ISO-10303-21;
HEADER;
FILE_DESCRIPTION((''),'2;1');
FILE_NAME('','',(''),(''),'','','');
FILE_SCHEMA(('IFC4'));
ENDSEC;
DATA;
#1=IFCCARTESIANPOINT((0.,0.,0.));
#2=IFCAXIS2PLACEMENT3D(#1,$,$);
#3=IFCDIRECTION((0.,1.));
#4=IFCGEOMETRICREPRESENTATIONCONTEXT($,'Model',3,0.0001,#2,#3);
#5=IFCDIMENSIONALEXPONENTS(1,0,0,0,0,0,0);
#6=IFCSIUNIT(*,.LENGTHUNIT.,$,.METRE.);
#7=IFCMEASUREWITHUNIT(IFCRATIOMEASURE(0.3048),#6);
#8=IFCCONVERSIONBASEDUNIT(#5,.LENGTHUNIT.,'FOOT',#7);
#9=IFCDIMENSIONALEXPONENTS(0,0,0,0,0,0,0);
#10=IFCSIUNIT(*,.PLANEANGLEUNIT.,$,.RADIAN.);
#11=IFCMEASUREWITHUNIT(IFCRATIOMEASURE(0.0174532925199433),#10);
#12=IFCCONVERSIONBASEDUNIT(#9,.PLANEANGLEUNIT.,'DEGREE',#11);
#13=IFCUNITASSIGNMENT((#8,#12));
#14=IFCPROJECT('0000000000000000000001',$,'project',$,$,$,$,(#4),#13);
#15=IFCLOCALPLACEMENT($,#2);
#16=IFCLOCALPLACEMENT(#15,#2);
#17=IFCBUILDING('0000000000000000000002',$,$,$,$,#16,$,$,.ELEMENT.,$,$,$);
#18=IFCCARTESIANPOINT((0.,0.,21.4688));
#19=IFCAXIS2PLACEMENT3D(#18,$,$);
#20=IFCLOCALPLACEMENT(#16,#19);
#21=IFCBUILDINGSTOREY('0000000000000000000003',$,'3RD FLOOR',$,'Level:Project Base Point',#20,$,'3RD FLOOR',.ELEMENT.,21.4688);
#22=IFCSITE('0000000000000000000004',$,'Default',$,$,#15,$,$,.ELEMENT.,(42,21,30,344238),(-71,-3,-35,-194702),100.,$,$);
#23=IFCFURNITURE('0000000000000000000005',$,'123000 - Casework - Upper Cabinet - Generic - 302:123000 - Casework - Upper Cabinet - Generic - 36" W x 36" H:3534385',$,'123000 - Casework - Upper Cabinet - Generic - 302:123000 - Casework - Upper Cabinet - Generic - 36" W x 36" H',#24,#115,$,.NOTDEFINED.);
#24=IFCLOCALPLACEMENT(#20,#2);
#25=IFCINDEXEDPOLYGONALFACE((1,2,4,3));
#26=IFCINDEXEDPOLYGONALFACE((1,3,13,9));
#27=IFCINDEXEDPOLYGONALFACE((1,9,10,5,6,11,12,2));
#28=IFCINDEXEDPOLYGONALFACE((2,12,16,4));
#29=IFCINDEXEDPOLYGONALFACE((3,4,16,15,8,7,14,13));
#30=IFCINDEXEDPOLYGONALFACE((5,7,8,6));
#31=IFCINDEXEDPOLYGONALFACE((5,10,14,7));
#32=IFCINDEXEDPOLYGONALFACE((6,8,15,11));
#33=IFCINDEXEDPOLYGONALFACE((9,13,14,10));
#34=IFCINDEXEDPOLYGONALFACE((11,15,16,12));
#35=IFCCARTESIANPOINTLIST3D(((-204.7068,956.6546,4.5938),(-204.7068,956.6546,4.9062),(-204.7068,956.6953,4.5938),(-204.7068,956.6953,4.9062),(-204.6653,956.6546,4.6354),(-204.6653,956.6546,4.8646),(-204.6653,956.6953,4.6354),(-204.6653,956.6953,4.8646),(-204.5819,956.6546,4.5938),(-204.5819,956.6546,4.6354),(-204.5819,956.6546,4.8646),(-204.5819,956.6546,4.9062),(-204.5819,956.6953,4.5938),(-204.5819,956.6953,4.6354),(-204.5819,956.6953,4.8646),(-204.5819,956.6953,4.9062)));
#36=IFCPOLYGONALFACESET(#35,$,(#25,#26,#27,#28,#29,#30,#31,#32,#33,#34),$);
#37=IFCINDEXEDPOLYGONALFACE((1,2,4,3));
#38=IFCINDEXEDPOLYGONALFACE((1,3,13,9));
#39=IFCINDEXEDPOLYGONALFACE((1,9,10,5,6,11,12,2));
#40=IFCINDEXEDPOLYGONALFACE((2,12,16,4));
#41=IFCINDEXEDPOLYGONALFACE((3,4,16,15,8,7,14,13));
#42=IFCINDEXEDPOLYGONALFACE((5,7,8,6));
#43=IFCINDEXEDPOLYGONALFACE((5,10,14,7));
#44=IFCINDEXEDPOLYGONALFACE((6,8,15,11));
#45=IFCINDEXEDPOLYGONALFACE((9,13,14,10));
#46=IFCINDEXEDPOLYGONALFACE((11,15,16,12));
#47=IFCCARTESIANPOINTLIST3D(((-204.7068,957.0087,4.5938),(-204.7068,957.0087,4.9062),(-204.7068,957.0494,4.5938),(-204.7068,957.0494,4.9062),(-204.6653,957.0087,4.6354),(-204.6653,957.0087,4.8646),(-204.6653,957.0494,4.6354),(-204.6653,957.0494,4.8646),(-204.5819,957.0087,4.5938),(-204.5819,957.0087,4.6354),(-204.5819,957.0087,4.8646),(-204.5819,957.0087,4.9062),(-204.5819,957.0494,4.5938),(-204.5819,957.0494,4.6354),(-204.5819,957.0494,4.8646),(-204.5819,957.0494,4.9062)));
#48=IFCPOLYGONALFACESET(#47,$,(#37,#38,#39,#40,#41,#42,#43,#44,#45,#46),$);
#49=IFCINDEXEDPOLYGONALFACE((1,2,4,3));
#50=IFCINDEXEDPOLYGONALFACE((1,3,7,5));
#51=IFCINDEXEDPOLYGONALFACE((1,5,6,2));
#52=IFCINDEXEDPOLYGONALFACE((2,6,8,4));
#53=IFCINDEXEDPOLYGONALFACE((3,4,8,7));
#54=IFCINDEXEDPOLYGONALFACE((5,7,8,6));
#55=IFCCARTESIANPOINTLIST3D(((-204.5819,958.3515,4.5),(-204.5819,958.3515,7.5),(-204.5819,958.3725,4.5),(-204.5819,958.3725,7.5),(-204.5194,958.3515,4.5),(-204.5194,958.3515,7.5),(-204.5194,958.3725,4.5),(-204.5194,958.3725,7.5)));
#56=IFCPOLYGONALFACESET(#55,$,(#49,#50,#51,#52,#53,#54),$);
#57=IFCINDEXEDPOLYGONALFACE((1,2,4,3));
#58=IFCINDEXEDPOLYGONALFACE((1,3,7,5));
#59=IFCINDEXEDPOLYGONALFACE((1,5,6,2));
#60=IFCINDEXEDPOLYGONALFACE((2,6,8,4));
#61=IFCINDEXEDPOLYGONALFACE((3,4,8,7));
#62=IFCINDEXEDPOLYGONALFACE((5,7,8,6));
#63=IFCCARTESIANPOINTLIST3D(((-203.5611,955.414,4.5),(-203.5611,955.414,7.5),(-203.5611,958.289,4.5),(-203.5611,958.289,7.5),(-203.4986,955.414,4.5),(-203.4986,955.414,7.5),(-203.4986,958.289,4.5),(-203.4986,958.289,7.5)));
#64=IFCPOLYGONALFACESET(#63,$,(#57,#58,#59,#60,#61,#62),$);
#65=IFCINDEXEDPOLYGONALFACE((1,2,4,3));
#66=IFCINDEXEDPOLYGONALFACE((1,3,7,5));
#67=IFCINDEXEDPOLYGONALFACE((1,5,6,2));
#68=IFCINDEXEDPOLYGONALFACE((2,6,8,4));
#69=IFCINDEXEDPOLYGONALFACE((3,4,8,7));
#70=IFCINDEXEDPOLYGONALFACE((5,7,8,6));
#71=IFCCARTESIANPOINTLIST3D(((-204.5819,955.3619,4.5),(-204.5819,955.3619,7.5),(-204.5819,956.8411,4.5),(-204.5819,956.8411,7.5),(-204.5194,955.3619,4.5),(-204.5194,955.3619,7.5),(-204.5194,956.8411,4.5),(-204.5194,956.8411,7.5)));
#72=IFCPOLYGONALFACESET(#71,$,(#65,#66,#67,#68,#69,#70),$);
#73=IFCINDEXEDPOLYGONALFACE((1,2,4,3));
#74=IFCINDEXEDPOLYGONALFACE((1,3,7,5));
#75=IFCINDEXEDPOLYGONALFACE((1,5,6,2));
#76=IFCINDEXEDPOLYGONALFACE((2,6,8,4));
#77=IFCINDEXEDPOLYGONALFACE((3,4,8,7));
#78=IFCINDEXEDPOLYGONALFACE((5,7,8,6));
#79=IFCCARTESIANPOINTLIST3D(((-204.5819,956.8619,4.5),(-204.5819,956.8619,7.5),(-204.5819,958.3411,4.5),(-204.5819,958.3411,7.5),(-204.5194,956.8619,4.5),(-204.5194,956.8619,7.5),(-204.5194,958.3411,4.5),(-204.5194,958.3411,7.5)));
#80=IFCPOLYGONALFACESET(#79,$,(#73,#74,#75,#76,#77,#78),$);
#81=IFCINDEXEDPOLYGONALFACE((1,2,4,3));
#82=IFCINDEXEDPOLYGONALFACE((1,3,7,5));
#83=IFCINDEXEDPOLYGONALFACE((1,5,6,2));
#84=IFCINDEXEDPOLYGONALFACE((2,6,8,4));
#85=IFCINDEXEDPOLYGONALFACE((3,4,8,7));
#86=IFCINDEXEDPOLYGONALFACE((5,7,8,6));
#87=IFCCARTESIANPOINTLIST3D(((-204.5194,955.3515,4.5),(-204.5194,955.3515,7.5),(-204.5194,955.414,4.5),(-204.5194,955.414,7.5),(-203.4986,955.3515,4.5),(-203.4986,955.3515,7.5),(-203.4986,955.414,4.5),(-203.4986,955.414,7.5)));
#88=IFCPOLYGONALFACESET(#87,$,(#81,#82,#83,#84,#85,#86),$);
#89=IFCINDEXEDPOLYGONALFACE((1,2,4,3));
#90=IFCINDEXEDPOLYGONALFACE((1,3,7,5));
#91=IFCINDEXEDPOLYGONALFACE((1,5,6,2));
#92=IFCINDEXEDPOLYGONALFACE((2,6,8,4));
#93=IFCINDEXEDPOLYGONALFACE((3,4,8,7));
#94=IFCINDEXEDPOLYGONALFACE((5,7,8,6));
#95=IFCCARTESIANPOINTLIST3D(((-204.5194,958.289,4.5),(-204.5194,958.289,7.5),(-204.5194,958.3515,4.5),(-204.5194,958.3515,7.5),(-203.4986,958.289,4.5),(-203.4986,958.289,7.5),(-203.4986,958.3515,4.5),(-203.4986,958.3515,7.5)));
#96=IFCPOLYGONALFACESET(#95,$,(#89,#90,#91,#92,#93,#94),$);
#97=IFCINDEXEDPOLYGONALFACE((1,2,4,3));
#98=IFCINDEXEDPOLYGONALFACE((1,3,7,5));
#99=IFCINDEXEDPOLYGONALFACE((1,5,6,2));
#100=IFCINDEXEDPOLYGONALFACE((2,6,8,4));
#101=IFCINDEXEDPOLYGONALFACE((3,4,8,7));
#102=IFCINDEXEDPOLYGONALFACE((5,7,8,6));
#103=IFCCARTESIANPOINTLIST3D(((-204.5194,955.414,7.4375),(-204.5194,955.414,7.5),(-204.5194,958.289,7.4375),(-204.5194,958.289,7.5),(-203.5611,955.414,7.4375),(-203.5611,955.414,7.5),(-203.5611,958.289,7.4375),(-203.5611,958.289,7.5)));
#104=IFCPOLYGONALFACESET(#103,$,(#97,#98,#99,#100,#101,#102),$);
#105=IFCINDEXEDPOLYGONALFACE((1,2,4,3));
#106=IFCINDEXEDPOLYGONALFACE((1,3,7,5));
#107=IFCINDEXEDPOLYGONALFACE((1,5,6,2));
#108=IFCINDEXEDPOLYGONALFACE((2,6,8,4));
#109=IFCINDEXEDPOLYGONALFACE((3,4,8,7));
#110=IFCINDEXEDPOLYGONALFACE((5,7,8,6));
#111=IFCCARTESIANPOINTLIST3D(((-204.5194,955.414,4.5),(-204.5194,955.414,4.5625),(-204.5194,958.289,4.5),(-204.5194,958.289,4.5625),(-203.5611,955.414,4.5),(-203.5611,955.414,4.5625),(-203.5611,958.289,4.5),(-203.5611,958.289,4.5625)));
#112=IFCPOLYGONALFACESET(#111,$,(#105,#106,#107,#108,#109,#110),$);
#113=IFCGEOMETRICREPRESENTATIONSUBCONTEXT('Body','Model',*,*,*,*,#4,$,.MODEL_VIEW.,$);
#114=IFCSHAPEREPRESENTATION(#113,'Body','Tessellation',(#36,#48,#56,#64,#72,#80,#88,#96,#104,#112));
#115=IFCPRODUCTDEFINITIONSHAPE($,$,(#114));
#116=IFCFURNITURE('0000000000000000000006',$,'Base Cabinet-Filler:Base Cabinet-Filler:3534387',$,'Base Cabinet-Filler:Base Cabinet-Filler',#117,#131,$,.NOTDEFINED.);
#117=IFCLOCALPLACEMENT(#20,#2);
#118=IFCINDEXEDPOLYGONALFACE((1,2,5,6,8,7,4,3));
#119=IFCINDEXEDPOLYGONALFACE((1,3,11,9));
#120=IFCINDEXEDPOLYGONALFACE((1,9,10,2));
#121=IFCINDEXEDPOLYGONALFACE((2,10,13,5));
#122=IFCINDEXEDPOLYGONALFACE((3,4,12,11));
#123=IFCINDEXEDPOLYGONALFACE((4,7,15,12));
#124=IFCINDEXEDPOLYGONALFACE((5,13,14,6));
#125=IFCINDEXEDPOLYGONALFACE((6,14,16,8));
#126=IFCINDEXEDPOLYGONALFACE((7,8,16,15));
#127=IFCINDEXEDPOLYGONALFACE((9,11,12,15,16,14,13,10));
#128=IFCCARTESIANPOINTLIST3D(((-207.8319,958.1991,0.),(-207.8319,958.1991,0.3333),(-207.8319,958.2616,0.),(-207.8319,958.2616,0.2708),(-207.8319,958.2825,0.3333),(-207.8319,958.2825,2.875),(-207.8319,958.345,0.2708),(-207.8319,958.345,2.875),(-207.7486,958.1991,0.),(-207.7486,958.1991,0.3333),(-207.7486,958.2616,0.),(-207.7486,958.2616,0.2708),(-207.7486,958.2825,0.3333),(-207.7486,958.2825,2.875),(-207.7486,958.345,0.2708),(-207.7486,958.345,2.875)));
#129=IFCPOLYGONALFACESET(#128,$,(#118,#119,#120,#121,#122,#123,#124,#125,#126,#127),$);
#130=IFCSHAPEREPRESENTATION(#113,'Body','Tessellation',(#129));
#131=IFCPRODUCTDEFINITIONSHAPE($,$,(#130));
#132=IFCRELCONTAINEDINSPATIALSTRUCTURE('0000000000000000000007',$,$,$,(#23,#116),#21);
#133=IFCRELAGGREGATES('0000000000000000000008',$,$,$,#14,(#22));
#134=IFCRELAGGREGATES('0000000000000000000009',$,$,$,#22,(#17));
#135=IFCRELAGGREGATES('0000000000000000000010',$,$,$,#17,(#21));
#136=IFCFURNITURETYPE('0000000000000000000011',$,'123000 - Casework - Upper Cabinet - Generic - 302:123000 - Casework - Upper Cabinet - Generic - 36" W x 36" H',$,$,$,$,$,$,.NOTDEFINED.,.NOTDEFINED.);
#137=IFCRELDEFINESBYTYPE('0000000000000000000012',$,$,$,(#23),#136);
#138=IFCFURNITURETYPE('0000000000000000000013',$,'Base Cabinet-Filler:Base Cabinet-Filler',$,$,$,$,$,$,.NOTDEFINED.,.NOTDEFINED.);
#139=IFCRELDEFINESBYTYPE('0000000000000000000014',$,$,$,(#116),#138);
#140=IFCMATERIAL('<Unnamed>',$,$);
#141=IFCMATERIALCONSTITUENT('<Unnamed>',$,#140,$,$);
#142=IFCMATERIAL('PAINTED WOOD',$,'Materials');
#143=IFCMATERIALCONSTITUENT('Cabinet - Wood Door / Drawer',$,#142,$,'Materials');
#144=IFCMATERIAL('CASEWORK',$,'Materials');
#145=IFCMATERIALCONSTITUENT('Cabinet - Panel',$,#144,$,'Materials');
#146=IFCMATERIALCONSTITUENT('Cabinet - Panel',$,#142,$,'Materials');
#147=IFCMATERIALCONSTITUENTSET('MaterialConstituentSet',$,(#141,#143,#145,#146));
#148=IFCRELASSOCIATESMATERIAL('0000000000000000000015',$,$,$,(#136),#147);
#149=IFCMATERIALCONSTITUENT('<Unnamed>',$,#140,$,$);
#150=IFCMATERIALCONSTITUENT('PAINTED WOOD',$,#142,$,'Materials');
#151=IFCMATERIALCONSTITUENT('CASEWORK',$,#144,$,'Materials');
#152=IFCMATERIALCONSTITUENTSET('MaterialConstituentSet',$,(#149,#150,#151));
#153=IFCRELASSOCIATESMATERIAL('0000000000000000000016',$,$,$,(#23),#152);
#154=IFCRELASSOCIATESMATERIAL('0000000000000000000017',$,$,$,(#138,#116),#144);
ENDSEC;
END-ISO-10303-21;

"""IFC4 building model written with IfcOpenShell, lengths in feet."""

from ifc_helpers import new_model, entity, si_unit, converted_unit, direction, frame, frame_2d, origin, origin_2d_with_axis, place, context, subcontext, project, spatial, polyline, rectangle, outline, extrude, source, transform, mapped, material, constituent, constituent_set, type_object, type_shapes, element, save


model = new_model("IFC4")

# Units and contexts
model_context = context("Model", 3, precision=0.0001, world=origin(), true_north=direction((0.0, 1.0)))
body_context = subcontext(model_context, "Body", "Model", "MODEL_VIEW")
ifc_project = project(units=[converted_unit("LENGTHUNIT", "FOOT", entity("IfcRatioMeasure", 0.3048), si_unit("LENGTHUNIT", "METRE"), dimensions=[1, 0, 0, 0, 0, 0, 0]), converted_unit("PLANEANGLEUNIT", "DEGREE", entity("IfcRatioMeasure", 0.0174532925199433), si_unit("PLANEANGLEUNIT", "RADIAN"), dimensions=[0, 0, 0, 0, 0, 0, 0])], contexts=[model_context])

# Site, building, storey
site_placement = place(None, origin())
site = spatial("IfcSite", under=ifc_project, at=site_placement, Name="Default", CompositionType="ELEMENT", RefLatitude=(42, 21, 30, 344238), RefLongitude=(-71, -3, -35, -194702), RefElevation=100.0)
building_placement = place(site_placement, origin())
building = spatial("IfcBuilding", under=site, at=building_placement, CompositionType="ELEMENT")
storey_placement = place(building_placement, frame((0.0, 0.0, 21.4688)))
storey = spatial("IfcBuildingStorey", under=building, at=storey_placement, Name="3RD FLOOR", ObjectType="Level:Project Base Point", LongName="3RD FLOOR", CompositionType="ELEMENT", Elevation=21.4688)

# Furniture
ifc_material_1 = material(Name="CASEWORK", Category="Materials")
ifc_material_2 = material(Name="<Unnamed>")
ifc_material_3 = material(Name="PAINTED WOOD", Category="Materials")
ifc_constituent_1 = constituent(ifc_material_2, Name="<Unnamed>")
ifc_constituent_2 = constituent(ifc_material_3, Name="PAINTED WOOD", Category="Materials")
ifc_constituent_3 = constituent(ifc_material_1, Name="CASEWORK", Category="Materials")
ifc_constituent_set_1 = constituent_set(constituents=[ifc_constituent_1, ifc_constituent_2, ifc_constituent_3], Name="MaterialConstituentSet")
ifc_constituent_4 = constituent(ifc_material_2, Name="<Unnamed>")
ifc_constituent_5 = constituent(ifc_material_3, Name="Cabinet - Wood Door / Drawer", Category="Materials")
ifc_constituent_6 = constituent(ifc_material_1, Name="Cabinet - Panel", Category="Materials")
ifc_constituent_7 = constituent(ifc_material_3, Name="Cabinet - Panel", Category="Materials")
ifc_constituent_set_2 = constituent_set(constituents=[ifc_constituent_4, ifc_constituent_5, ifc_constituent_6, ifc_constituent_7], Name="MaterialConstituentSet")
furniture_type_1 = type_object("IfcFurnitureType", Name="123000 - Casework - Upper Cabinet - Generic - 302:123000 - Casework - Upper Cabinet - Generic - 36\" W x 36\" H", AssemblyPlace="NOTDEFINED", PredefinedType="NOTDEFINED", material=ifc_constituent_set_2)
shared_shape_1 = source(origin(), body_context, "Body", "SweptSolid", [
    extrude(outline(polyline([(-0.0521, -0.1146), (-0.0521, -0.1562), (0.0729, -0.1562), (0.0729, 0.1562), (-0.0521, 0.1562), (-0.0521, 0.1146), (0.0313, 0.1146), (0.0313, -0.1146), (-0.0521, -0.1146)])), frame((1.303, 1.1354, 0.25), z_axis=(-1.0, 0.0, 0.0), x_axis=(0.0, 1.0, 0.0)), (0.0, 0.0, -1.0), 0.0407),
    extrude(outline(polyline([(-0.0521, -0.1146), (-0.0521, -0.1562), (0.0729, -0.1562), (0.0729, 0.1562), (-0.0521, 0.1562), (-0.0521, 0.1146), (0.0313, 0.1146), (0.0313, -0.1146), (-0.0521, -0.1146)])), frame((1.6572, 1.1354, 0.25), z_axis=(-1.0, 0.0, 0.0), x_axis=(0.0, 1.0, 0.0)), (0.0, 0.0, -1.0), 0.0407),
    extrude(rectangle(XDim=0.021, YDim=0.0625, at=frame_2d((0.0, 0.0), x_axis=(1.0, 0.0))), frame((3.0105, 1.0521, 0.0)), (0.0, 0.0, 1.0), 3.0),
    extrude(rectangle(XDim=2.875, YDim=0.0625, at=frame_2d((0.0, 0.0), x_axis=(1.0, 0.0))), frame((1.5, 0.0313, 0.0), z_axis=(0.0, 0.0, 1.0), x_axis=(-1.0, 0.0, 0.0)), (0.0, 0.0, 1.0), 3.0),
    extrude(rectangle(XDim=1.4792, YDim=0.0625, at=origin_2d_with_axis()), frame((0.75, 1.0521, 0.0)), (0.0, 0.0, 1.0), 3.0),
    extrude(rectangle(XDim=1.4792, YDim=0.0625, at=origin_2d_with_axis()), frame((2.25, 1.0521, 0.0)), (0.0, 0.0, 1.0), 3.0),
    extrude(rectangle(XDim=1.0208, YDim=0.0625, at=origin_2d_with_axis()), frame((0.0312, 0.5104, 0.0), z_axis=(0.0, 0.0, 1.0), x_axis=(0.0, 1.0, 0.0)), (0.0, 0.0, 1.0), 3.0),
    extrude(rectangle(XDim=1.0208, YDim=0.0625, at=frame_2d((0.0, 0.0), x_axis=(1.0, 0.0))), frame((2.9688, 0.5104, 0.0), z_axis=(0.0, 0.0, 1.0), x_axis=(0.0, 1.0, 0.0)), (0.0, 0.0, 1.0), 3.0),
    extrude(rectangle(XDim=0.9583, YDim=2.875, at=frame_2d((0.0, 0.0), x_axis=(1.0, 0.0))), frame((1.5, 0.5417, 2.9375), z_axis=(0.0, 0.0, 1.0), x_axis=(0.0, 1.0, 0.0)), (0.0, 0.0, 1.0), 0.0625),
    extrude(rectangle(XDim=0.9583, YDim=2.875, at=frame_2d((0.0, 0.0), x_axis=(1.0, 0.0))), frame((1.5, 0.5417, 0.0), z_axis=(0.0, 0.0, 1.0), x_axis=(0.0, 1.0, 0.0)), (0.0, 0.0, 1.0), 0.0625),
])
type_shapes(furniture_type_1, [shared_shape_1])
furniture_1_placement = place(storey_placement, frame((-203.4986, 955.3515, 4.5), z_axis=(0.0, 0.0, 1.0), x_axis=(0.0, 1.0, 0.0)))
element("IfcFurniture", 1, at=furniture_1_placement, inside=storey, type_object=furniture_type_1, material=ifc_constituent_set_1, Name="123000 - Casework - Upper Cabinet - Generic - 302:123000 - Casework - Upper Cabinet - Generic - 36\" W x 36\" H:3534385", ObjectType="123000 - Casework - Upper Cabinet - Generic - 302:123000 - Casework - Upper Cabinet - Generic - 36\" W x 36\" H", PredefinedType="NOTDEFINED", context=body_context, shape_type="MappedRepresentation", body=[
    mapped(shared_shape_1, transform((0.0, 0.0, 0.0), scale=1.0)),
])
furniture_type_2 = type_object("IfcFurnitureType", Name="Base Cabinet-Filler:Base Cabinet-Filler", AssemblyPlace="NOTDEFINED", PredefinedType="NOTDEFINED", material=ifc_material_1)
shared_shape_2 = source(origin(), body_context, "Body", "SweptSolid", [
    extrude(outline(polyline([(-0.599, -0.0729), (2.0052, -0.0729), (2.0052, -0.0104), (-0.5365, -0.0104), (-0.5365, 0.0729), (-0.8698, 0.0729), (-0.8698, 0.0104), (-0.599, 0.0104), (-0.599, -0.0729)])), frame((0.0, 0.0729, 0.8698), z_axis=(1.0, 0.0, 0.0), x_axis=(0.0, 0.0, 1.0)), (0.0, 0.0, 1.0), 0.0833),
])
type_shapes(furniture_type_2, [shared_shape_2])
furniture_2_placement = place(storey_placement, frame((-207.8319, 958.1991, 0.0)))
element("IfcFurniture", 2, at=furniture_2_placement, inside=storey, type_object=furniture_type_2, material=ifc_material_1, Name="Base Cabinet-Filler:Base Cabinet-Filler:3534387", ObjectType="Base Cabinet-Filler:Base Cabinet-Filler", PredefinedType="NOTDEFINED", context=body_context, shape_type="MappedRepresentation", body=[
    mapped(shared_shape_2, transform((0.0, 0.0, 0.0), scale=1.0)),
])

save(model, "model.ifc")
